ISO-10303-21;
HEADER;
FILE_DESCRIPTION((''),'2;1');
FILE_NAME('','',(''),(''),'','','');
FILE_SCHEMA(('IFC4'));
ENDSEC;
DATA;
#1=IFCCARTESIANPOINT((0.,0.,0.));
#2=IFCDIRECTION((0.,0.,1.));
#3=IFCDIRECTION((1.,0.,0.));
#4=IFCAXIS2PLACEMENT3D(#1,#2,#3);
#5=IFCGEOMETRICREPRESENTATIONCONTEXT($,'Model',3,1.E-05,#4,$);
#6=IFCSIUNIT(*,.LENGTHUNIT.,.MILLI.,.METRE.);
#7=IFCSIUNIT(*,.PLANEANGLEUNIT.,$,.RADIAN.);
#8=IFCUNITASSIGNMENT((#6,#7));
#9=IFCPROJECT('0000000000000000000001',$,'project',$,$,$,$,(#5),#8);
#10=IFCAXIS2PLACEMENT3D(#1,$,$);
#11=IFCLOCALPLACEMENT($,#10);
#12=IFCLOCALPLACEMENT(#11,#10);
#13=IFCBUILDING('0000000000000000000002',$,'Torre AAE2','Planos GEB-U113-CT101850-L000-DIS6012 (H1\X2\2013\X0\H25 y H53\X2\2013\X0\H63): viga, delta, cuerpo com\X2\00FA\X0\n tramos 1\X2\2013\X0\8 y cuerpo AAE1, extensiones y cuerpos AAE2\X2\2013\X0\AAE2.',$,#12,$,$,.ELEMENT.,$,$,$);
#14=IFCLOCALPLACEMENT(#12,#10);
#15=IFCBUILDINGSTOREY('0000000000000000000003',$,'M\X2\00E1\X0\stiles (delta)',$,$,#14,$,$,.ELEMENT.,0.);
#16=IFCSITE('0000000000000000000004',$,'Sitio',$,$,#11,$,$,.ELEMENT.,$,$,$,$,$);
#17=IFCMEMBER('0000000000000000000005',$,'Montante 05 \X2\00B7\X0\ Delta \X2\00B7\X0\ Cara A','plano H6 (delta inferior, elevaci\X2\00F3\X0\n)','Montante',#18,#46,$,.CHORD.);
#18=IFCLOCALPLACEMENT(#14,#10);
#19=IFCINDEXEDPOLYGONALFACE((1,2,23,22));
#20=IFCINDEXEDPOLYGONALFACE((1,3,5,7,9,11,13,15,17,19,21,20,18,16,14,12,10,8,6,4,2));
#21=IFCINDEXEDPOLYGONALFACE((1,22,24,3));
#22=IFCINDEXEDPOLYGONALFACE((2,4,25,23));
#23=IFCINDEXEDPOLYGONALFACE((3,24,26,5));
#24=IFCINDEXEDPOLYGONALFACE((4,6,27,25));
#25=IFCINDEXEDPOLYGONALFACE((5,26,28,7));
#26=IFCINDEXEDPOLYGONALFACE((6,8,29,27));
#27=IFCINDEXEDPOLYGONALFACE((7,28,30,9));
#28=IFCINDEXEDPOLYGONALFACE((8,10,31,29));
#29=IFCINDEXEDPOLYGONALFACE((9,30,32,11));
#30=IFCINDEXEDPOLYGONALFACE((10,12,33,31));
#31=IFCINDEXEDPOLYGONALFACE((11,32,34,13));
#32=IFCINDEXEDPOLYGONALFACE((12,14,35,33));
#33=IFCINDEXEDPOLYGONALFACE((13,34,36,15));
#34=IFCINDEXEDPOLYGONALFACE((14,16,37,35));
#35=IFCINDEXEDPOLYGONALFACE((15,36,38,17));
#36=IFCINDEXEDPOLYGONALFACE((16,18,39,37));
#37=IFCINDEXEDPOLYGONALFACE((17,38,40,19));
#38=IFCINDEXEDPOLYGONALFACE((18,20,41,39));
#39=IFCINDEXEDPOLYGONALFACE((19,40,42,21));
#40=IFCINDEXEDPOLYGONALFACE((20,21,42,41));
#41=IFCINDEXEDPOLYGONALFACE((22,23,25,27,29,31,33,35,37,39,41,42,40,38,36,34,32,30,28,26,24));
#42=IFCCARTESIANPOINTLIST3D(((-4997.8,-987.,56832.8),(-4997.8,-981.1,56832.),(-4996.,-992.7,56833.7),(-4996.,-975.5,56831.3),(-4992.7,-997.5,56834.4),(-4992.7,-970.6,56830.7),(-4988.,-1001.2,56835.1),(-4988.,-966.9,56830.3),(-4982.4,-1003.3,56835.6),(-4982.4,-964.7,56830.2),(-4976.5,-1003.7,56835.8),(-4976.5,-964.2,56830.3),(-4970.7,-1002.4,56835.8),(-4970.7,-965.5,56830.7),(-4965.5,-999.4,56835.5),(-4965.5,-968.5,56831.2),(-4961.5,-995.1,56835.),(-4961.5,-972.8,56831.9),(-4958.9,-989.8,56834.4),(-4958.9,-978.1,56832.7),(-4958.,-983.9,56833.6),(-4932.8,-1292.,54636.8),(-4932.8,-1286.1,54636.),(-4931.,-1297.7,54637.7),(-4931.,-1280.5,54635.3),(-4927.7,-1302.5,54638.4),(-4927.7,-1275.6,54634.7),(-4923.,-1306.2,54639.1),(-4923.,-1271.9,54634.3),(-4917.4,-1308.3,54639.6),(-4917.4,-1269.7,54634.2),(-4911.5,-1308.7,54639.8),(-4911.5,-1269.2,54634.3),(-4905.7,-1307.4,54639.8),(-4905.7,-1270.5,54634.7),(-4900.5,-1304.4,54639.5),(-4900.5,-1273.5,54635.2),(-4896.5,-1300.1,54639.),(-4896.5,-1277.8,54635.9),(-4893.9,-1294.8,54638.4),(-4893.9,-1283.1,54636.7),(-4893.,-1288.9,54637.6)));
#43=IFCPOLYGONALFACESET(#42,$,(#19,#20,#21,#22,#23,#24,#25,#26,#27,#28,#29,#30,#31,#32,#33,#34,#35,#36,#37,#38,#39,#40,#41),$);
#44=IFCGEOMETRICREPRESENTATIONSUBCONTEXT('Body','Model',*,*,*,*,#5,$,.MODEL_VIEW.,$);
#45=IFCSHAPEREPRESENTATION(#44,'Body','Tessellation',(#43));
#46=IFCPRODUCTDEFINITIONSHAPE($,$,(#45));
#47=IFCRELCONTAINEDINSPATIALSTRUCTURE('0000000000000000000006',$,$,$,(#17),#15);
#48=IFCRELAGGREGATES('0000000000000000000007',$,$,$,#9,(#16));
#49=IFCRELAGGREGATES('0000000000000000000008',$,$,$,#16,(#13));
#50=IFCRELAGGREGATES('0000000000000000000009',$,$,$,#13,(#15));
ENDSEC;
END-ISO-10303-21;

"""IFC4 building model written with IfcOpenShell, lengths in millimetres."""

from ifc_helpers import new_model, si_unit, frame, origin, origin_with_axes, place, context, subcontext, project, spatial, circle, extrude, element, save


model = new_model("IFC4")

# Units and contexts
model_context = context("Model", 3, precision=1e-05, world=origin_with_axes())
body_context = subcontext(model_context, "Body", "Model", "MODEL_VIEW")
ifc_project = project(units=[si_unit("LENGTHUNIT", "METRE", prefix="MILLI"), si_unit("PLANEANGLEUNIT", "RADIAN")], contexts=[model_context])

# Site, building, storey
site_placement = place(None, origin())
site = spatial("IfcSite", under=ifc_project, at=site_placement, Name="Sitio", CompositionType="ELEMENT")
building_placement = place(site_placement, origin())
building = spatial("IfcBuilding", under=site, at=building_placement, Name="Torre AAE2", Description="Planos GEB-U113-CT101850-L000-DIS6012 (H1–H25 y H53–H63): viga, delta, cuerpo común tramos 1–8 y cuerpo AAE1, extensiones y cuerpos AAE2–AAE2.", CompositionType="ELEMENT")
storey_placement = place(building_placement, origin())
storey = spatial("IfcBuildingStorey", under=building, at=storey_placement, Name="Mástiles (delta)", CompositionType="ELEMENT", Elevation=0.0)

# Member
member_placement = place(storey_placement, frame((-4913.0, -1289.0, 54637.0), z_axis=(-0.029305, 0.137509, 0.990067), x_axis=(0.999571, 0.004031, 0.029027)))
element("IfcMember", 1, at=member_placement, inside=storey, Name="Montante 05 · Delta · Cara A", Description="plano H6 (delta inferior, elevación)", ObjectType="Montante", PredefinedType="CHORD", context=body_context, shape_type="SweptSolid", body=[
    extrude(circle(Radius=20.0), None, (0.0, 0.0, 1.0), 2218.0),
])

save(model, "model.ifc")
